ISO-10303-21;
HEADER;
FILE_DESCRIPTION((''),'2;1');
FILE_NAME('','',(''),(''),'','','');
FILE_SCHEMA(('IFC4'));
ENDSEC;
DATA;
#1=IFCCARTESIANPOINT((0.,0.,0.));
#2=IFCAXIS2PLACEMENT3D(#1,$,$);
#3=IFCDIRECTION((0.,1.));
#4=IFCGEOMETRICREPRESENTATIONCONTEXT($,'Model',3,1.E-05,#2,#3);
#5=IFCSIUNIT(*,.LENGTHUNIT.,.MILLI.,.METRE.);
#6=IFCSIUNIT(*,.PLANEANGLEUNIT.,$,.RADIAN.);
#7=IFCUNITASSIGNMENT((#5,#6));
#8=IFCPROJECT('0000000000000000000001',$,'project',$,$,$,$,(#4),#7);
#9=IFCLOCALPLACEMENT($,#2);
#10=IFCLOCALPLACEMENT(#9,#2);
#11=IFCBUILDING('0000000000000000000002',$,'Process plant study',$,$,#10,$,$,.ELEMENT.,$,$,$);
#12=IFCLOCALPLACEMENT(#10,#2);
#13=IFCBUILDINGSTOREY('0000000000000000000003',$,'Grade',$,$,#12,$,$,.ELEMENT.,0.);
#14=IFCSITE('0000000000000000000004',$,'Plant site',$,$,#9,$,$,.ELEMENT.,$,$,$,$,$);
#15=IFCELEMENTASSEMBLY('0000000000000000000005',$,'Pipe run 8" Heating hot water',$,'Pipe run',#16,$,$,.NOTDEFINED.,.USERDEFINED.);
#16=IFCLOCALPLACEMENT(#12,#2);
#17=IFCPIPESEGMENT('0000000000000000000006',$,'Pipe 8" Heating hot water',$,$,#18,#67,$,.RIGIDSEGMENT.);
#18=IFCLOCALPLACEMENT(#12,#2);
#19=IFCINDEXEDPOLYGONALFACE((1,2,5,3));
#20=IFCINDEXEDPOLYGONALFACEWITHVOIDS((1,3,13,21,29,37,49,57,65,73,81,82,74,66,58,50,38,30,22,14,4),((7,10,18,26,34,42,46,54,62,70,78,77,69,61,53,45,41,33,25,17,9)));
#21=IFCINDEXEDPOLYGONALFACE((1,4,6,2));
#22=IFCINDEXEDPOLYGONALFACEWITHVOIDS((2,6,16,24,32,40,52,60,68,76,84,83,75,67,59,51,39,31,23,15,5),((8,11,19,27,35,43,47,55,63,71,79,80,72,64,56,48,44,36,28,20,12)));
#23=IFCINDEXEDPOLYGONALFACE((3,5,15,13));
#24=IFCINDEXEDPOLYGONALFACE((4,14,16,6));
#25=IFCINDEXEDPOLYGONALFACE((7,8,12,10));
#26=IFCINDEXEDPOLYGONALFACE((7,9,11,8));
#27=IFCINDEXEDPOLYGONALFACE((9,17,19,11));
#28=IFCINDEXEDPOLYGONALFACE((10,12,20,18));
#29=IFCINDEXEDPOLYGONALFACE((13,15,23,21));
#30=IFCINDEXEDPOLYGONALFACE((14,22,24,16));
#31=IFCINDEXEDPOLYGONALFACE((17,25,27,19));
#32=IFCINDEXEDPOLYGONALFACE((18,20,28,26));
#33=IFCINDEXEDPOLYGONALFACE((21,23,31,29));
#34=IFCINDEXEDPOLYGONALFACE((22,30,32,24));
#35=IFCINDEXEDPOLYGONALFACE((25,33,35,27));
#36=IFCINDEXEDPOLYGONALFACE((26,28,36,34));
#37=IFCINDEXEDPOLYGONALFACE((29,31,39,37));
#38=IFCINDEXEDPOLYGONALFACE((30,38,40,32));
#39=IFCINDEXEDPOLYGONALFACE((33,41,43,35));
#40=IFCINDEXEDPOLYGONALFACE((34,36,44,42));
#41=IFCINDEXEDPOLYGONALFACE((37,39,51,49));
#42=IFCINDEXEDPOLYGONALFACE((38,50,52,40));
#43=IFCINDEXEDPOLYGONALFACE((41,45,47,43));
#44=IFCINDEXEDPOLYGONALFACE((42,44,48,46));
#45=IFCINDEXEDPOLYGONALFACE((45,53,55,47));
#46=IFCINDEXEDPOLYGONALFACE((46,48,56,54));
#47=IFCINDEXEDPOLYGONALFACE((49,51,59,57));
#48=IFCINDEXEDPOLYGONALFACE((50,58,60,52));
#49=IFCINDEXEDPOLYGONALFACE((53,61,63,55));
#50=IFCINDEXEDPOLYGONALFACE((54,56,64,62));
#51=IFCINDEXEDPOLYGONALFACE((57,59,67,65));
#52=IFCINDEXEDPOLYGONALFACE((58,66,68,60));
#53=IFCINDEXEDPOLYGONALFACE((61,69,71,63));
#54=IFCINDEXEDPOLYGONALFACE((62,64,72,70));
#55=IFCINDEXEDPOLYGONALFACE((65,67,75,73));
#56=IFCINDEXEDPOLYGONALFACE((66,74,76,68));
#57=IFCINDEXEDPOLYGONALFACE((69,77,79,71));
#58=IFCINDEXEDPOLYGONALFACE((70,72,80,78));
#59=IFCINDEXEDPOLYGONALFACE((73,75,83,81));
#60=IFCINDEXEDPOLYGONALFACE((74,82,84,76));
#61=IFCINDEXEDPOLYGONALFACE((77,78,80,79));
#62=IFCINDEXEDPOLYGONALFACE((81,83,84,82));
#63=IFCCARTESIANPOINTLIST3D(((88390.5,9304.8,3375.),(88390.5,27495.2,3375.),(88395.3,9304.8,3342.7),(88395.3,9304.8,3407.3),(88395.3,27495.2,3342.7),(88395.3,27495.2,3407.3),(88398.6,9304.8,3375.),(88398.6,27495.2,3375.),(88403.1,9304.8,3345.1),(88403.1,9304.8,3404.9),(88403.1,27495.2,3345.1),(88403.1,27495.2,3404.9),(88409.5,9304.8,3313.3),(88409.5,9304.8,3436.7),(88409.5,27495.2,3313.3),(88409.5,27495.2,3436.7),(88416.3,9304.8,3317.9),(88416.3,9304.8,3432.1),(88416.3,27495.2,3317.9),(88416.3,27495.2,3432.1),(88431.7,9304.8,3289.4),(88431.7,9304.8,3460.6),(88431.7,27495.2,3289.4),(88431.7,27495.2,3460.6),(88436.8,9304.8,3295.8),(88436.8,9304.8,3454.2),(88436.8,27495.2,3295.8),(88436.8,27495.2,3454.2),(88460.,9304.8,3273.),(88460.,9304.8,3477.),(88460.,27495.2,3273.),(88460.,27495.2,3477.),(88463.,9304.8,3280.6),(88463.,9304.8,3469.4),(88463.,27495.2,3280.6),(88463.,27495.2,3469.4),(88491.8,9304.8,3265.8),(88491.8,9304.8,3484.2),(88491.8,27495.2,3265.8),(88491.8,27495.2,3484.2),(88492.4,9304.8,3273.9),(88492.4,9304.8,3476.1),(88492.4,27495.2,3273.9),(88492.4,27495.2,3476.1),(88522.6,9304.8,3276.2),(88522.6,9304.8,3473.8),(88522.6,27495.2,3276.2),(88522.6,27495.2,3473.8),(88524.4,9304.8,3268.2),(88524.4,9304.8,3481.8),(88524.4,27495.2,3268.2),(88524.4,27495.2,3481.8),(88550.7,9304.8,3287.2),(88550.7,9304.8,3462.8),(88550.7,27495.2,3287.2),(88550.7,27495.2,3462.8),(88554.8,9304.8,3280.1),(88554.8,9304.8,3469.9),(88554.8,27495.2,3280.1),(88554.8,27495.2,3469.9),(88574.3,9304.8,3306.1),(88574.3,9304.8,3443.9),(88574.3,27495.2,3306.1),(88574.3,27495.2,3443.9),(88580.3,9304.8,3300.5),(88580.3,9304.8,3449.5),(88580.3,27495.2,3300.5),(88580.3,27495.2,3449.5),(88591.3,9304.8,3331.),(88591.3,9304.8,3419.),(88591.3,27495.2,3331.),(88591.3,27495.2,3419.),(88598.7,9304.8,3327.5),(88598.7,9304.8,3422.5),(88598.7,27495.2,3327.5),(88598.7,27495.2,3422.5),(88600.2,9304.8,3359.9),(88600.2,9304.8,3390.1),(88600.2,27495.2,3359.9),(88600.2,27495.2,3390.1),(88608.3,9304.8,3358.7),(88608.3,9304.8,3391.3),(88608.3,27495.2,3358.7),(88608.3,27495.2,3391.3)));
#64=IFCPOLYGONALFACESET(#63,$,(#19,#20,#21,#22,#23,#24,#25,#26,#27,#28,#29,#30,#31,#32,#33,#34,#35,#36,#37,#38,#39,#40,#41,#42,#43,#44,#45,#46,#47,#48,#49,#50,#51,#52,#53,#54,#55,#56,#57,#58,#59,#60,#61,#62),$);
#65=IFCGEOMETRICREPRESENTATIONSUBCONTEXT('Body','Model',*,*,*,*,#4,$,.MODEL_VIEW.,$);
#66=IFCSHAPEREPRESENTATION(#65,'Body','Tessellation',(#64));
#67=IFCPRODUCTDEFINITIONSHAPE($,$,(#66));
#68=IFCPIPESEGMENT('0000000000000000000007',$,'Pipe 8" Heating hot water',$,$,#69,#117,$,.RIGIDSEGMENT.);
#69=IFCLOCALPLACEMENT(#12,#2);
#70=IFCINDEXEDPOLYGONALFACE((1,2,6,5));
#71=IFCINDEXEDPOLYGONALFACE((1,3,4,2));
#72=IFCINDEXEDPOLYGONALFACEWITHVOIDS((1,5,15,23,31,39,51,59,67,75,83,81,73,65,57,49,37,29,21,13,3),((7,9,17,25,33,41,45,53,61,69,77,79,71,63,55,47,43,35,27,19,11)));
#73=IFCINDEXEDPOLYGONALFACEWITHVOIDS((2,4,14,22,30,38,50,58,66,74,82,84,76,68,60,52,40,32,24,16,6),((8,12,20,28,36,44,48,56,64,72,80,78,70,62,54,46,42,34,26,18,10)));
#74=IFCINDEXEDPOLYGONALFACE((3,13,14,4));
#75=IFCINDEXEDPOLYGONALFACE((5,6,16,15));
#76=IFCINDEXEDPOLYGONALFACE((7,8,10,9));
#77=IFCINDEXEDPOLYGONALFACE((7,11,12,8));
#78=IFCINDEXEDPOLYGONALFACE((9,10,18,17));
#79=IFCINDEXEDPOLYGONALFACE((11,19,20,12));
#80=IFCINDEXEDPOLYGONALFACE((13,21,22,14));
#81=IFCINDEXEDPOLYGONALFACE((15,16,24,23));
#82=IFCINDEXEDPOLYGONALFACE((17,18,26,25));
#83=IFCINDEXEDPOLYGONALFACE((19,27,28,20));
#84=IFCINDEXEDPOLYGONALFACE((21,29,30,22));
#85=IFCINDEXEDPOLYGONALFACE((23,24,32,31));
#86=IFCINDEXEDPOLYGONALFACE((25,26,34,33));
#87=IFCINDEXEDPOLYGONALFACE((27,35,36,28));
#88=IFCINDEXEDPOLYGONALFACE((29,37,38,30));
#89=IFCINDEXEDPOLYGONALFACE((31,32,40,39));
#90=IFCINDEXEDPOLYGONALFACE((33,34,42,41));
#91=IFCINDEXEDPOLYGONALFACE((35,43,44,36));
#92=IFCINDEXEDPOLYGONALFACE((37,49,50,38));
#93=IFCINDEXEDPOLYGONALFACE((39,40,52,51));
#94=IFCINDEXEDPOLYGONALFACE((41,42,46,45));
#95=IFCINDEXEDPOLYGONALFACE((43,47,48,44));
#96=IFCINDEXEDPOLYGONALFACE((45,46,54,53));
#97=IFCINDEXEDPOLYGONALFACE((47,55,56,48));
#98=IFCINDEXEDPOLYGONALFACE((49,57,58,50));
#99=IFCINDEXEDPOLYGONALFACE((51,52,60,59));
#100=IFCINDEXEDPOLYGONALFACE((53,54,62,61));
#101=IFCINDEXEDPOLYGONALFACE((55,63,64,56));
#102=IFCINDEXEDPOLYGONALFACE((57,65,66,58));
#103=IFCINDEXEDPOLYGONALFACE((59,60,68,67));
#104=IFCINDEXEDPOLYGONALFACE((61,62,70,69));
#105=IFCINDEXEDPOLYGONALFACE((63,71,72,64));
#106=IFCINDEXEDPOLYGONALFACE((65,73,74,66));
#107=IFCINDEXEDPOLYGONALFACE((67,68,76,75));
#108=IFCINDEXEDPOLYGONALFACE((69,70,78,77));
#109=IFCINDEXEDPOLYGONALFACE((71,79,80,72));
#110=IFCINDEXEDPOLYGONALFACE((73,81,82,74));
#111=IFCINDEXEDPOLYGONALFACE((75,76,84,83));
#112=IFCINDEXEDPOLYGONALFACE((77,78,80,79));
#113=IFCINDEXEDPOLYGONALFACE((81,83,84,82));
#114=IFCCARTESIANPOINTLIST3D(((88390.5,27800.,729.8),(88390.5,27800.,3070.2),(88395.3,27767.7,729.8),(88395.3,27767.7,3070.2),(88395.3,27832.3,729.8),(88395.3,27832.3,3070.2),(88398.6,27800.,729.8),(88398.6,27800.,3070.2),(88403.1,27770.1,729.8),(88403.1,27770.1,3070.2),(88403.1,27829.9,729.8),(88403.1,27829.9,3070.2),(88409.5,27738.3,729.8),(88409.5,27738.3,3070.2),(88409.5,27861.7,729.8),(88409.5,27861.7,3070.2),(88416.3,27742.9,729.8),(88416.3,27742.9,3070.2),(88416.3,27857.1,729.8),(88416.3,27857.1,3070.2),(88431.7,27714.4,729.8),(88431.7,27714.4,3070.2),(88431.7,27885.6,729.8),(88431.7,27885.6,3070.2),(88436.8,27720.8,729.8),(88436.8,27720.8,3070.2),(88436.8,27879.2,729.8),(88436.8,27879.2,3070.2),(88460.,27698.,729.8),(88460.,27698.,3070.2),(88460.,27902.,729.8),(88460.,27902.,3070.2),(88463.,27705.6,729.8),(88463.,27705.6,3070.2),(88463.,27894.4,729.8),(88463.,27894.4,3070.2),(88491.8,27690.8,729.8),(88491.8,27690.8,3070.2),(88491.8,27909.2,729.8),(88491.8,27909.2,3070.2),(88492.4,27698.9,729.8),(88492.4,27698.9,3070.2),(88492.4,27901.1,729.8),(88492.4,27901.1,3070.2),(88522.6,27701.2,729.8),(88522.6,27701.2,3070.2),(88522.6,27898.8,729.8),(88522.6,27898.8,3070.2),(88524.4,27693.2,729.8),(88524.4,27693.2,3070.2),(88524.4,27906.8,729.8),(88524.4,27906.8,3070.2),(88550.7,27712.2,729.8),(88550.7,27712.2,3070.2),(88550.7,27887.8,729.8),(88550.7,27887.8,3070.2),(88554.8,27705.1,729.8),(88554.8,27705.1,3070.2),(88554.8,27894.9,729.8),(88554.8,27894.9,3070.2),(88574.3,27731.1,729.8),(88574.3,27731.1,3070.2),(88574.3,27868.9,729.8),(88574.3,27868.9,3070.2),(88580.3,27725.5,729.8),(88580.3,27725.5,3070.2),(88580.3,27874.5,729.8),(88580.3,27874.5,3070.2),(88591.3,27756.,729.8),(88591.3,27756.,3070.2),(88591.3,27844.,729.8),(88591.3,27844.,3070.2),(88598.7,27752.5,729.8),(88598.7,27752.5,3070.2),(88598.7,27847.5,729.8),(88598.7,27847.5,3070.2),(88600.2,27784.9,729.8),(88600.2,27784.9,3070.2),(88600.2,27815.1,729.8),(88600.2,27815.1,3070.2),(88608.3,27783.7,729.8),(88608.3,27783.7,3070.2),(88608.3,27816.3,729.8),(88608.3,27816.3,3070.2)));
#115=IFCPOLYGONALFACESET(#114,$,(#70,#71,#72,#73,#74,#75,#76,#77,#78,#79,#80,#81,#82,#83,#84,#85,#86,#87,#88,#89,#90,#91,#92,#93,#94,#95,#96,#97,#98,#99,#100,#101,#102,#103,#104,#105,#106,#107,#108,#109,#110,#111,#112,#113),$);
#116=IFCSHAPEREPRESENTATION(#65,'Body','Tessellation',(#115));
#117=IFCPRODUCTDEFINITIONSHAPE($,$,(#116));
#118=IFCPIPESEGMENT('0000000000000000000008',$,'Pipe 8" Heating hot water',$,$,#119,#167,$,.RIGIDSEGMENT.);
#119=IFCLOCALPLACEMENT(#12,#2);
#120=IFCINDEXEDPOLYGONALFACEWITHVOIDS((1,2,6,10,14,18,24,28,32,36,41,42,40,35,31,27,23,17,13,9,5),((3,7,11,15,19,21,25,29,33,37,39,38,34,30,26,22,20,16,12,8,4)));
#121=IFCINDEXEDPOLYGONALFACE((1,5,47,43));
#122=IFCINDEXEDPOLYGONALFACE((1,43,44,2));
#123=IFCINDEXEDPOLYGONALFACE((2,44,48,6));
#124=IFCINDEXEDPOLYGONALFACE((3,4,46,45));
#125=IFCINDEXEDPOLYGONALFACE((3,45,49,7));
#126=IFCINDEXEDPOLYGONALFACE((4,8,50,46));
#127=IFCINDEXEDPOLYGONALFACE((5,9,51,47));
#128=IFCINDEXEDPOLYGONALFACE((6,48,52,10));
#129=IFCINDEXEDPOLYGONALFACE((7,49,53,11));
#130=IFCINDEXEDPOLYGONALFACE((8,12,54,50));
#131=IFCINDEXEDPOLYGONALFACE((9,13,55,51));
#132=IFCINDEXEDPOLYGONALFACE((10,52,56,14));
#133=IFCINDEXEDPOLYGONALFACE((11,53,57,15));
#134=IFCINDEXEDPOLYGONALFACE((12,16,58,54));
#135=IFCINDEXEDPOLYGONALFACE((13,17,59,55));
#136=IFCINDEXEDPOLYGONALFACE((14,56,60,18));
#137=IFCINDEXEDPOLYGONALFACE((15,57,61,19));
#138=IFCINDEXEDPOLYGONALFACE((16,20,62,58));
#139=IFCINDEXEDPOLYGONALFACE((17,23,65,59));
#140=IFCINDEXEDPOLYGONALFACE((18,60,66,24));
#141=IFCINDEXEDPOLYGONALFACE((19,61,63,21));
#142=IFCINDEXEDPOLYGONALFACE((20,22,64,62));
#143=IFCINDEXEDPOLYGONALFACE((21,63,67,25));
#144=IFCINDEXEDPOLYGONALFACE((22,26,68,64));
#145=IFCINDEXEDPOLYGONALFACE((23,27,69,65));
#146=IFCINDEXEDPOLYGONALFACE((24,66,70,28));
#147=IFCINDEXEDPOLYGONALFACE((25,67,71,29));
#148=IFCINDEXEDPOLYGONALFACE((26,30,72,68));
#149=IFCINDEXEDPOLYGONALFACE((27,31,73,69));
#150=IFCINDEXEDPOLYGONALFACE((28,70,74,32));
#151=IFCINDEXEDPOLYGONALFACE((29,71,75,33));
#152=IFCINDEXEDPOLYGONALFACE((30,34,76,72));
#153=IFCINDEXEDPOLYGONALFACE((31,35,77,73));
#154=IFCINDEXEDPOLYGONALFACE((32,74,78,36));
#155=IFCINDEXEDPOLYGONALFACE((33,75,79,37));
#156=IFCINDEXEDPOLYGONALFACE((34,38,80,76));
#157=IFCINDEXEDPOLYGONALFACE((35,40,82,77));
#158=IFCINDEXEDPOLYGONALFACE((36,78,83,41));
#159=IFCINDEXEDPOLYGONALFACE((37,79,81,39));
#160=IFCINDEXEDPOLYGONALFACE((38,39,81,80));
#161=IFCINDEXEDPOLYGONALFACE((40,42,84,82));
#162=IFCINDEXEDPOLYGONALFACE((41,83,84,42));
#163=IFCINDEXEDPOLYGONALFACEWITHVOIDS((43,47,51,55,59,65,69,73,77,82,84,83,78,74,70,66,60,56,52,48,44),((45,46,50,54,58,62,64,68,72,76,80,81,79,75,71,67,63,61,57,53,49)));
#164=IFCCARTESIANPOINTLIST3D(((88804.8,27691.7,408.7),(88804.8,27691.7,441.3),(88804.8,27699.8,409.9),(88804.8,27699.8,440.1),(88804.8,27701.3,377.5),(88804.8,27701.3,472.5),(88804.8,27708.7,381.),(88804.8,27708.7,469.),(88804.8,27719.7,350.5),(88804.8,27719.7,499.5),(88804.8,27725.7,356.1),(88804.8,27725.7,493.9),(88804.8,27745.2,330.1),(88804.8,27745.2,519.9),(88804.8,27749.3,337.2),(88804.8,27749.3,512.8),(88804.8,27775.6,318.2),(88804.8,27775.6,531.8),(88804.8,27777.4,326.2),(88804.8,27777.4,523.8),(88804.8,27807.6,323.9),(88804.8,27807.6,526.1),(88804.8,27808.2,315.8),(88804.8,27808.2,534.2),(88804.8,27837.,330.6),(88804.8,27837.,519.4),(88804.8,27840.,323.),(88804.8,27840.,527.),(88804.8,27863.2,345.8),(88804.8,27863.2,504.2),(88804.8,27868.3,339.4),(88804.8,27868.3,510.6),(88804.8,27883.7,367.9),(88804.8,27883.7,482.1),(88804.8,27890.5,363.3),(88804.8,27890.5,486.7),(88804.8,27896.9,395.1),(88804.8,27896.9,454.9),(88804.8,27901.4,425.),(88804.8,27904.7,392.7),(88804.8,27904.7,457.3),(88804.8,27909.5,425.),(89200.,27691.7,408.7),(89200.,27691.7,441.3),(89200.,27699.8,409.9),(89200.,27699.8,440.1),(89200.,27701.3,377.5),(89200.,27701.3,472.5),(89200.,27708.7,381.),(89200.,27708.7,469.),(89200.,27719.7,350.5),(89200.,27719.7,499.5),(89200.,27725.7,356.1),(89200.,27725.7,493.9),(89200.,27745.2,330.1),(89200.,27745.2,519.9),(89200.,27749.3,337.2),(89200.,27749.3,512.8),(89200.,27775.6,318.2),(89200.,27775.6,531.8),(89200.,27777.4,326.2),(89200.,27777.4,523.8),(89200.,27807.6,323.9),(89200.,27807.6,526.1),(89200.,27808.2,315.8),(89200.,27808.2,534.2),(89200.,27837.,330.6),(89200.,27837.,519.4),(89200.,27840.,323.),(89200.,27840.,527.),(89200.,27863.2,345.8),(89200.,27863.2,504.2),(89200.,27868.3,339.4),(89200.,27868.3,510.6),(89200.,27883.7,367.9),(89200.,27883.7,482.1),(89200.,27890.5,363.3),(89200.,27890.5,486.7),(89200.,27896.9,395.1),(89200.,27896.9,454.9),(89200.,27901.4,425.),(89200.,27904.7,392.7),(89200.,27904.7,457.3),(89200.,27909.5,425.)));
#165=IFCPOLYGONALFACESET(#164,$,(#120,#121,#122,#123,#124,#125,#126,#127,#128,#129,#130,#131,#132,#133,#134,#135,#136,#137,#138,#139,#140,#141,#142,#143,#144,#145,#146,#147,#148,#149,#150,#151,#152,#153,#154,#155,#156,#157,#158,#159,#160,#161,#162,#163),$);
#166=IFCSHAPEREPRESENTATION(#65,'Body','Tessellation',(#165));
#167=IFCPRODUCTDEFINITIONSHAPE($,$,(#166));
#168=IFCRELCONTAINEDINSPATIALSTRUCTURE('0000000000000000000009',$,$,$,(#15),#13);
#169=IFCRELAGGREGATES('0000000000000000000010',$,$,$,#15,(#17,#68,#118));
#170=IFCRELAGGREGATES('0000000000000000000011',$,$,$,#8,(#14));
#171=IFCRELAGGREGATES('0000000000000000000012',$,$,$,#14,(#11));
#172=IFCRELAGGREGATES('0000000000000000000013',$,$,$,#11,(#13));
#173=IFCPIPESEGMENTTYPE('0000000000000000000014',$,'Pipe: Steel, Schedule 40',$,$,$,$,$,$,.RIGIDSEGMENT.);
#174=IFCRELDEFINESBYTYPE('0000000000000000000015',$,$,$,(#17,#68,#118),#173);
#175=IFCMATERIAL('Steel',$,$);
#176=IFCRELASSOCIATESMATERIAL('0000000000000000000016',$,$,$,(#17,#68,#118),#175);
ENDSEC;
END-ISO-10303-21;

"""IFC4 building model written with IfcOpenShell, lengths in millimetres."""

from ifc_helpers import new_model, si_unit, direction, frame, origin, origin_with_axes, origin_2d, place, context, subcontext, project, spatial, hollow_circle, extrude, material, type_object, element, aggregate, save


model = new_model("IFC4")

# Units and contexts
model_context = context("Model", 3, precision=1e-05, world=origin(), true_north=direction((0.0, 1.0)))
body_context = subcontext(model_context, "Body", "Model", "MODEL_VIEW")
ifc_project = project(units=[si_unit("LENGTHUNIT", "METRE", prefix="MILLI"), si_unit("PLANEANGLEUNIT", "RADIAN")], contexts=[model_context])

# Site, building, storey
site_placement = place(None, origin())
site = spatial("IfcSite", under=ifc_project, at=site_placement, Name="Plant site", CompositionType="ELEMENT")
building_placement = place(site_placement, origin())
building = spatial("IfcBuilding", under=site, at=building_placement, Name="Process plant study", CompositionType="ELEMENT")
storey_placement = place(building_placement, origin())
storey = spatial("IfcBuildingStorey", under=building, at=storey_placement, Name="Grade", CompositionType="ELEMENT", Elevation=0.0)

# Shared definitions
ifc_material = material(Name="Steel")
pipe_segment_type = type_object("IfcPipeSegmentType", Name="Pipe: Steel, Schedule 40", PredefinedType="RIGIDSEGMENT")

# Element assembly, pipe segments
assembly_1_placement = place(storey_placement, origin_with_axes())
assembly_1 = element("IfcElementAssembly", 1, at=assembly_1_placement, inside=storey, Name="Pipe run 8\" Heating hot water", ObjectType="Pipe run", AssemblyPlace="NOTDEFINED", PredefinedType="USERDEFINED")
pipe_segment_1_placement = place(storey_placement, origin_with_axes())
pipe_segment_1 = element("IfcPipeSegment", 2, at=pipe_segment_1_placement, type_object=pipe_segment_type, material=ifc_material, Name="Pipe 8\" Heating hot water", PredefinedType="RIGIDSEGMENT", context=body_context, shape_type="SweptSolid", body=[
    extrude(hollow_circle(Radius=109.5, WallThickness=8.2, at=origin_2d()), frame((88500.0, 9304.8, 3375.0), z_axis=(0.0, 1.0, 0.0), x_axis=(-1.0, 0.0, 0.0)), (0.0, 0.0, 1.0), 18190.4),
])
pipe_segment_2_placement = place(storey_placement, origin_with_axes())
pipe_segment_2 = element("IfcPipeSegment", 3, at=pipe_segment_2_placement, type_object=pipe_segment_type, material=ifc_material, Name="Pipe 8\" Heating hot water", PredefinedType="RIGIDSEGMENT", context=body_context, shape_type="SweptSolid", body=[
    extrude(hollow_circle(Radius=109.5, WallThickness=8.2, at=origin_2d()), frame((88500.0, 27800.0, 3070.2), z_axis=(0.0, 0.0, -1.0), x_axis=(-1.0, 0.0, 0.0)), (0.0, 0.0, 1.0), 2340.4),
])
pipe_segment_3_placement = place(storey_placement, origin_with_axes())
pipe_segment_3 = element("IfcPipeSegment", 4, at=pipe_segment_3_placement, type_object=pipe_segment_type, material=ifc_material, Name="Pipe 8\" Heating hot water", PredefinedType="RIGIDSEGMENT", context=body_context, shape_type="SweptSolid", body=[
    extrude(hollow_circle(Radius=109.5, WallThickness=8.2, at=origin_2d()), frame((88804.8, 27800.0, 425.0), z_axis=(1.0, 0.0, 0.0), x_axis=(0.0, 1.0, 0.0)), (0.0, 0.0, 1.0), 395.2),
])

aggregate(assembly_1, [pipe_segment_1, pipe_segment_2, pipe_segment_3])

save(model, "model.ifc")
